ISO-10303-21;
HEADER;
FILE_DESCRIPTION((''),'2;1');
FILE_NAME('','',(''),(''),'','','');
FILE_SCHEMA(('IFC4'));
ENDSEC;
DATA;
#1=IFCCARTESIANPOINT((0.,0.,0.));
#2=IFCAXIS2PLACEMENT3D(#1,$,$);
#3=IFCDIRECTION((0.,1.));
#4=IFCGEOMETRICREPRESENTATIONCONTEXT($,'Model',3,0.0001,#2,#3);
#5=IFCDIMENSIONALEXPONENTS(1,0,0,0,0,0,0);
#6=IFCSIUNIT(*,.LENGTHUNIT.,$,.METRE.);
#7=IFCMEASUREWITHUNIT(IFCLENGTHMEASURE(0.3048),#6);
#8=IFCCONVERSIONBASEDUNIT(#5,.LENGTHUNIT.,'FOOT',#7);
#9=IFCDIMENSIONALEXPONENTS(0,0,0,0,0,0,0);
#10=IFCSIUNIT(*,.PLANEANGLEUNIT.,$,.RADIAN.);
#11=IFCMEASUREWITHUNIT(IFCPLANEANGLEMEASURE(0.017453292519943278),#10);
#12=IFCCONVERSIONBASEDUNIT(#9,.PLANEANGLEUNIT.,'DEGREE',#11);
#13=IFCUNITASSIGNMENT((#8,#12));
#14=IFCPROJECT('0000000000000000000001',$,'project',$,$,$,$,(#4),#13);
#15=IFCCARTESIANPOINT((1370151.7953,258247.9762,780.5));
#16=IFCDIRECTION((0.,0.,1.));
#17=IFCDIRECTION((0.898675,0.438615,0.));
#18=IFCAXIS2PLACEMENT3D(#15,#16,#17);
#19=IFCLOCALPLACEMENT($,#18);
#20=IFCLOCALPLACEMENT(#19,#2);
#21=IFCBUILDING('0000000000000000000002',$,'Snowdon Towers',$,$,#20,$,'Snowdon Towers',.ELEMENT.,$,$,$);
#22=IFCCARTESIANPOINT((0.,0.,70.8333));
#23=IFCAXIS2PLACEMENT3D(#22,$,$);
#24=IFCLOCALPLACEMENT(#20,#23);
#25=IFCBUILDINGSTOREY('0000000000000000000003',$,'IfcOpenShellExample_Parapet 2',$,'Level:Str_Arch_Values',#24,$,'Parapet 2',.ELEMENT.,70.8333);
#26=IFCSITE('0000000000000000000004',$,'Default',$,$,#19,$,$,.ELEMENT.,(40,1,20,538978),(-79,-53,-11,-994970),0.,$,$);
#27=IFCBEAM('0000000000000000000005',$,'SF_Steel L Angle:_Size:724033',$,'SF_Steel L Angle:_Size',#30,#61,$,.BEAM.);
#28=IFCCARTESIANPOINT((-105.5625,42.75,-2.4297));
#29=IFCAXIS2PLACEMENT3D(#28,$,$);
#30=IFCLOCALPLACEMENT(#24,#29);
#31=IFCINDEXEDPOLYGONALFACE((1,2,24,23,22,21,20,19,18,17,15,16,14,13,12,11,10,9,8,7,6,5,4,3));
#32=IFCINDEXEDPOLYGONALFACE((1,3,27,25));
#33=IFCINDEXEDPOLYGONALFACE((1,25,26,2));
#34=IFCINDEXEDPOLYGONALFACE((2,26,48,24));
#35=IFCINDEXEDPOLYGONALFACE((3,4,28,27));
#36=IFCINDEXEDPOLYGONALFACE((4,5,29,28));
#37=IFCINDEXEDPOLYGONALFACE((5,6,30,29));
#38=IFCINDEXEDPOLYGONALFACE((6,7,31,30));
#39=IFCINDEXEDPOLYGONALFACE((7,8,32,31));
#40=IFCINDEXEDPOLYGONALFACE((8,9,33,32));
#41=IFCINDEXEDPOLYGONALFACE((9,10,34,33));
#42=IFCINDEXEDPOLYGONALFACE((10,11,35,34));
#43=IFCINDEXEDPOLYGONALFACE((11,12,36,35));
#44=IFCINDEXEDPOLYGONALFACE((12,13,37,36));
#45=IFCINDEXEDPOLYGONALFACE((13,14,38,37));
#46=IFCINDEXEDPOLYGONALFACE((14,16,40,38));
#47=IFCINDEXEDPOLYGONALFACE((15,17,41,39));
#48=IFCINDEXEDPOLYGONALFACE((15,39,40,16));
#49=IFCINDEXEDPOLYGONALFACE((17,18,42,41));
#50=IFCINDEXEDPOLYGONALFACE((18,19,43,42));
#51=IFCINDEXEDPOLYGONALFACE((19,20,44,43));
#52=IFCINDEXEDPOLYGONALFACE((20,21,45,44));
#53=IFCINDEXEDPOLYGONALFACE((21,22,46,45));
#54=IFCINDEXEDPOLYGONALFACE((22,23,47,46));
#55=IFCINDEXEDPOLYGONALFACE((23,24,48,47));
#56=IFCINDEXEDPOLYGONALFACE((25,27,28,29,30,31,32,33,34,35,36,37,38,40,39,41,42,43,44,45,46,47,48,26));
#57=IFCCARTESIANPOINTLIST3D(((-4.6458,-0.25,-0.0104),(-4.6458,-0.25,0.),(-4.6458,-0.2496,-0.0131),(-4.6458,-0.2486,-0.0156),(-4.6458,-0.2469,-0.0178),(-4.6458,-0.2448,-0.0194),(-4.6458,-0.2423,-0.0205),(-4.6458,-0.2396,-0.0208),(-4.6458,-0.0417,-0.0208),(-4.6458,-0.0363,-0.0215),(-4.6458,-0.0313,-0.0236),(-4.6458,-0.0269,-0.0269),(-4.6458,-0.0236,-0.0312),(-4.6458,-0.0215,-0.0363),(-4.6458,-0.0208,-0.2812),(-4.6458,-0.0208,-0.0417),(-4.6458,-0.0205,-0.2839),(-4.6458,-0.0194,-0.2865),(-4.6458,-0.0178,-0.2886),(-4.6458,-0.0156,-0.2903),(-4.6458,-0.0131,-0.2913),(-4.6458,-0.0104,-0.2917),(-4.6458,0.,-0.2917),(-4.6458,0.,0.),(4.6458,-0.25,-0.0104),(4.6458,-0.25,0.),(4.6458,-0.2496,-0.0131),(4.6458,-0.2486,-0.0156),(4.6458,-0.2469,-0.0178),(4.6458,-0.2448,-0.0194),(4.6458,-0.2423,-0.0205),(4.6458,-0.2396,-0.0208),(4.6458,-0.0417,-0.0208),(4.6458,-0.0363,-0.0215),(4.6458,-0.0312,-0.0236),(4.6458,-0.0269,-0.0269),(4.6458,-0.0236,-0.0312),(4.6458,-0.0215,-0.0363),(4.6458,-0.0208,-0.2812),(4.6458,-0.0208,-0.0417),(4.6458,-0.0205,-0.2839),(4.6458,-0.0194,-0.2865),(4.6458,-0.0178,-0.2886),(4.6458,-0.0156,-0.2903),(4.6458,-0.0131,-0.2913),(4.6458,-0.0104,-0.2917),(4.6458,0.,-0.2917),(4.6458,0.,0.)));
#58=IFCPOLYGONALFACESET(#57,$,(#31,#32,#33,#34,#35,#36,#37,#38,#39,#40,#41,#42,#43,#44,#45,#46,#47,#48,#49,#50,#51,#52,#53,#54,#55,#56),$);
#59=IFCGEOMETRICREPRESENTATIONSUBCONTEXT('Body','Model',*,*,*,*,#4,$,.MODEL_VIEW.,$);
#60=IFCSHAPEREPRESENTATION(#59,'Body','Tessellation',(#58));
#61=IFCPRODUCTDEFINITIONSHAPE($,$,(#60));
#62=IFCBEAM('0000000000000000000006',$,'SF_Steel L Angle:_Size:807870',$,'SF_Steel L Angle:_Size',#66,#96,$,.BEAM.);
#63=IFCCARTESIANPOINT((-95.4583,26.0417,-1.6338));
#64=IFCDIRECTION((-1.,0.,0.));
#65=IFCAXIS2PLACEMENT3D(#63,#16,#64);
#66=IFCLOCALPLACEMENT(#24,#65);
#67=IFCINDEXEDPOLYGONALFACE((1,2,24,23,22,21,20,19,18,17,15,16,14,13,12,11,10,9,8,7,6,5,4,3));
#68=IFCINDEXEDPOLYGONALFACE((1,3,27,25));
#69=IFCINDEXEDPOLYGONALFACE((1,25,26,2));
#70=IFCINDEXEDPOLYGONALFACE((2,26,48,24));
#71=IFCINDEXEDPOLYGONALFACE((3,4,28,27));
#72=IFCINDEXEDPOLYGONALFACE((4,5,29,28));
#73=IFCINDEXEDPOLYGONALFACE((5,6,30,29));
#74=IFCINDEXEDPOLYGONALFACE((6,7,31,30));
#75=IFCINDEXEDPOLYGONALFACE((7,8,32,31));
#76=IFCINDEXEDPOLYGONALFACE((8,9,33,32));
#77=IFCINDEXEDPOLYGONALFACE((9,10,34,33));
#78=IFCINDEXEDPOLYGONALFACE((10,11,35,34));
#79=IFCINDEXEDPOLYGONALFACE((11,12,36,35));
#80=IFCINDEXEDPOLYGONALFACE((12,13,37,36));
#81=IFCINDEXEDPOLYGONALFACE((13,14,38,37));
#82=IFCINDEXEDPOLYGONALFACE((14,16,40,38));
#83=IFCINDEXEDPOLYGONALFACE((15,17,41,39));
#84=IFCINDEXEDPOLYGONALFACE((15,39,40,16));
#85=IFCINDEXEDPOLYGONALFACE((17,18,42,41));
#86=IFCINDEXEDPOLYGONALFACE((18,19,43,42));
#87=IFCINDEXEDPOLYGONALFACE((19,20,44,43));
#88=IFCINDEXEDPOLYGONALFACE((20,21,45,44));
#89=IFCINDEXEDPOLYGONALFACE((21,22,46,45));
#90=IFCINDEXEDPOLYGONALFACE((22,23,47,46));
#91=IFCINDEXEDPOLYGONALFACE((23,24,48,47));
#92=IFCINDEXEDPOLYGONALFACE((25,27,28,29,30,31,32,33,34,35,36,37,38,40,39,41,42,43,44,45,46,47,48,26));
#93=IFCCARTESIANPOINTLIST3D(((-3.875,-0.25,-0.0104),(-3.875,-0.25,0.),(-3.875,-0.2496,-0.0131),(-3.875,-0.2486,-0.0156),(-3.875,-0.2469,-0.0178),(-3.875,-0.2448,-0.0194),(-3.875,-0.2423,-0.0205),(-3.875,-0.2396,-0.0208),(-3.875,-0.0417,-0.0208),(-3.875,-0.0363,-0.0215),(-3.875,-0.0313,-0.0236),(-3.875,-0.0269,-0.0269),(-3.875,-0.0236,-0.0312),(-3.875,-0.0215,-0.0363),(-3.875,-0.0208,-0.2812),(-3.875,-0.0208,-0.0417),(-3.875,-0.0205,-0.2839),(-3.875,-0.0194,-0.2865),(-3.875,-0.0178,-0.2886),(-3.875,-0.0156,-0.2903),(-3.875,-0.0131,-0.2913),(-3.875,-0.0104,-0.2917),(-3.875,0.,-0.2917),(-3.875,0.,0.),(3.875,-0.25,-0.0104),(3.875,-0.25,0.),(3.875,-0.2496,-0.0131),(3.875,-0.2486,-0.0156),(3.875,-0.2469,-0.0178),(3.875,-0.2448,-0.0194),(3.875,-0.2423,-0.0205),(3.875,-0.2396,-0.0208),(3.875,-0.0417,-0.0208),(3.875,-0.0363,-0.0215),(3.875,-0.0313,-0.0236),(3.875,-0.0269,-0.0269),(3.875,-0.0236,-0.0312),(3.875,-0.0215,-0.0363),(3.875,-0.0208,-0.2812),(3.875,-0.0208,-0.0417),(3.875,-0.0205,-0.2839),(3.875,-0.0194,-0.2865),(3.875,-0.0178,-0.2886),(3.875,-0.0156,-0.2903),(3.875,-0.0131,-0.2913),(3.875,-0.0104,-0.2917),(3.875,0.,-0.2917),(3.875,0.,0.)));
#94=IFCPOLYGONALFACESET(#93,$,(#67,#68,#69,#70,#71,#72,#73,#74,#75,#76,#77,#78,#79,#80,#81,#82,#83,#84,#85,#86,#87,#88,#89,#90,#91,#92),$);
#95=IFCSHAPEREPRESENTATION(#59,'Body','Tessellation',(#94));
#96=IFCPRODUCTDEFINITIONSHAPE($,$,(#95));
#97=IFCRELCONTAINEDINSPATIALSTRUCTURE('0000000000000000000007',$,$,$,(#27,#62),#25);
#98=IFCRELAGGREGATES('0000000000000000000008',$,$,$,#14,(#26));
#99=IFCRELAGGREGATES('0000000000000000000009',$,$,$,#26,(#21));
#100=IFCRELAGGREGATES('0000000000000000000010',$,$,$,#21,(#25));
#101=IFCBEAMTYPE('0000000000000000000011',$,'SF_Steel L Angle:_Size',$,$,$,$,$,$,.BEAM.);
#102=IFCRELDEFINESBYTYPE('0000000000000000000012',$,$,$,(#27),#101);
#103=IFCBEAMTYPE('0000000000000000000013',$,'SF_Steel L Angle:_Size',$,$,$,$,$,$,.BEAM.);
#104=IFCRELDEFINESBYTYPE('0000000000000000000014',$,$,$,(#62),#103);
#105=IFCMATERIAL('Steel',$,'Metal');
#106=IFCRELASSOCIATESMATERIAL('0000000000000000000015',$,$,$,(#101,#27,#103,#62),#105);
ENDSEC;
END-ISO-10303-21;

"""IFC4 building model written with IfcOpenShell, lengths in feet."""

from ifc_helpers import new_model, entity, si_unit, converted_unit, direction, frame, origin, place, context, subcontext, project, spatial, line, arc, indexed_curve, outline, extrude, source, transform, mapped, material, type_object, type_shapes, element, save


model = new_model("IFC4")

# Units and contexts
model_context = context("Model", 3, precision=0.0001, world=origin(), true_north=direction((0.0, 1.0)))
body_context = subcontext(model_context, "Body", "Model", "MODEL_VIEW")
ifc_project = project(units=[converted_unit("LENGTHUNIT", "FOOT", entity("IfcLengthMeasure", 0.3048), si_unit("LENGTHUNIT", "METRE"), dimensions=[1, 0, 0, 0, 0, 0, 0]), converted_unit("PLANEANGLEUNIT", "DEGREE", entity("IfcPlaneAngleMeasure", 0.017453292519943278), si_unit("PLANEANGLEUNIT", "RADIAN"), dimensions=[0, 0, 0, 0, 0, 0, 0])], contexts=[model_context])

# Site, building, storey
site_placement = place(None, frame((1370151.7953, 258247.9762, 780.5), z_axis=(0.0, 0.0, 1.0), x_axis=(0.898675, 0.438615, 0.0)))
site = spatial("IfcSite", under=ifc_project, at=site_placement, Name="Default", CompositionType="ELEMENT", RefLatitude=(40, 1, 20, 538978), RefLongitude=(-79, -53, -11, -994970), RefElevation=0.0)
building_placement = place(site_placement, origin())
building = spatial("IfcBuilding", under=site, at=building_placement, Name="Snowdon Towers", LongName="Snowdon Towers", CompositionType="ELEMENT")
storey_placement = place(building_placement, frame((0.0, 0.0, 70.8333)))
storey = spatial("IfcBuildingStorey", under=building, at=storey_placement, Name="IfcOpenShellExample_Parapet 2", ObjectType="Level:Str_Arch_Values", LongName="Parapet 2", CompositionType="ELEMENT", Elevation=70.8333)

# Beams
ifc_material_1 = material(Name="Steel", Category="Metal")
beam_type_1 = type_object("IfcBeamType", Name="SF_Steel L Angle:_Size", PredefinedType="BEAM", material=ifc_material_1)
shared_shape_1 = source(origin(), body_context, "Body", "SweptSolid", [
    extrude(outline(indexed_curve([(-0.0926, -0.1065), (0.1574, -0.1065), (0.1574, -0.0961), (0.1544, -0.0887), (0.147, -0.0856), (-0.0509, -0.0856), (-0.0657, -0.0795), (-0.0718, -0.0648), (-0.0718, 0.1748), (-0.0748, 0.1821), (-0.0822, 0.1852), (-0.0926, 0.1852)], segments=[line(1, 2, 3), arc(3, 4, 5), line(5, 6), arc(6, 7, 8), line(8, 9), arc(9, 10, 11), line(11, 12, 1)], self_intersect=False)), frame((-4.6458, -0.0926, -0.1065), z_axis=(1.0, 0.0, 0.0), x_axis=(0.0, -1.0, 0.0)), (0.0, 0.0, 1.0), 9.2917),
])
type_shapes(beam_type_1, [shared_shape_1])
beam_1_placement = place(storey_placement, frame((-105.5625, 42.75, -2.4297)))
element("IfcBeam", 1, at=beam_1_placement, inside=storey, type_object=beam_type_1, material=ifc_material_1, Name="SF_Steel L Angle:_Size:724033", ObjectType="SF_Steel L Angle:_Size", PredefinedType="BEAM", context=body_context, shape_type="MappedRepresentation", body=[
    mapped(shared_shape_1, transform((0.0, 0.0, 0.0), scale=1.0)),
])
beam_type_2 = type_object("IfcBeamType", Name="SF_Steel L Angle:_Size", PredefinedType="BEAM", material=ifc_material_1)
shared_shape_2 = source(origin(), body_context, "Body", "SweptSolid", [
    extrude(outline(indexed_curve([(-0.0926, -0.1065), (0.1574, -0.1065), (0.1574, -0.0961), (0.1544, -0.0887), (0.147, -0.0856), (-0.0509, -0.0856), (-0.0657, -0.0795), (-0.0718, -0.0648), (-0.0718, 0.1748), (-0.0748, 0.1821), (-0.0822, 0.1852), (-0.0926, 0.1852)], segments=[line(1, 2, 3), arc(3, 4, 5), line(5, 6), arc(6, 7, 8), line(8, 9), arc(9, 10, 11), line(11, 12, 1)], self_intersect=False)), frame((-3.875, -0.0926, -0.1065), z_axis=(1.0, 0.0, 0.0), x_axis=(0.0, -1.0, 0.0)), (0.0, 0.0, 1.0), 7.75),
])
type_shapes(beam_type_2, [shared_shape_2])
beam_2_placement = place(storey_placement, frame((-95.4583, 26.0417, -1.6338), z_axis=(0.0, 0.0, 1.0), x_axis=(-1.0, 0.0, 0.0)))
element("IfcBeam", 2, at=beam_2_placement, inside=storey, type_object=beam_type_2, material=ifc_material_1, Name="SF_Steel L Angle:_Size:807870", ObjectType="SF_Steel L Angle:_Size", PredefinedType="BEAM", context=body_context, shape_type="MappedRepresentation", body=[
    mapped(shared_shape_2, transform((0.0, 0.0, 0.0), scale=1.0)),
])

save(model, "model.ifc")
